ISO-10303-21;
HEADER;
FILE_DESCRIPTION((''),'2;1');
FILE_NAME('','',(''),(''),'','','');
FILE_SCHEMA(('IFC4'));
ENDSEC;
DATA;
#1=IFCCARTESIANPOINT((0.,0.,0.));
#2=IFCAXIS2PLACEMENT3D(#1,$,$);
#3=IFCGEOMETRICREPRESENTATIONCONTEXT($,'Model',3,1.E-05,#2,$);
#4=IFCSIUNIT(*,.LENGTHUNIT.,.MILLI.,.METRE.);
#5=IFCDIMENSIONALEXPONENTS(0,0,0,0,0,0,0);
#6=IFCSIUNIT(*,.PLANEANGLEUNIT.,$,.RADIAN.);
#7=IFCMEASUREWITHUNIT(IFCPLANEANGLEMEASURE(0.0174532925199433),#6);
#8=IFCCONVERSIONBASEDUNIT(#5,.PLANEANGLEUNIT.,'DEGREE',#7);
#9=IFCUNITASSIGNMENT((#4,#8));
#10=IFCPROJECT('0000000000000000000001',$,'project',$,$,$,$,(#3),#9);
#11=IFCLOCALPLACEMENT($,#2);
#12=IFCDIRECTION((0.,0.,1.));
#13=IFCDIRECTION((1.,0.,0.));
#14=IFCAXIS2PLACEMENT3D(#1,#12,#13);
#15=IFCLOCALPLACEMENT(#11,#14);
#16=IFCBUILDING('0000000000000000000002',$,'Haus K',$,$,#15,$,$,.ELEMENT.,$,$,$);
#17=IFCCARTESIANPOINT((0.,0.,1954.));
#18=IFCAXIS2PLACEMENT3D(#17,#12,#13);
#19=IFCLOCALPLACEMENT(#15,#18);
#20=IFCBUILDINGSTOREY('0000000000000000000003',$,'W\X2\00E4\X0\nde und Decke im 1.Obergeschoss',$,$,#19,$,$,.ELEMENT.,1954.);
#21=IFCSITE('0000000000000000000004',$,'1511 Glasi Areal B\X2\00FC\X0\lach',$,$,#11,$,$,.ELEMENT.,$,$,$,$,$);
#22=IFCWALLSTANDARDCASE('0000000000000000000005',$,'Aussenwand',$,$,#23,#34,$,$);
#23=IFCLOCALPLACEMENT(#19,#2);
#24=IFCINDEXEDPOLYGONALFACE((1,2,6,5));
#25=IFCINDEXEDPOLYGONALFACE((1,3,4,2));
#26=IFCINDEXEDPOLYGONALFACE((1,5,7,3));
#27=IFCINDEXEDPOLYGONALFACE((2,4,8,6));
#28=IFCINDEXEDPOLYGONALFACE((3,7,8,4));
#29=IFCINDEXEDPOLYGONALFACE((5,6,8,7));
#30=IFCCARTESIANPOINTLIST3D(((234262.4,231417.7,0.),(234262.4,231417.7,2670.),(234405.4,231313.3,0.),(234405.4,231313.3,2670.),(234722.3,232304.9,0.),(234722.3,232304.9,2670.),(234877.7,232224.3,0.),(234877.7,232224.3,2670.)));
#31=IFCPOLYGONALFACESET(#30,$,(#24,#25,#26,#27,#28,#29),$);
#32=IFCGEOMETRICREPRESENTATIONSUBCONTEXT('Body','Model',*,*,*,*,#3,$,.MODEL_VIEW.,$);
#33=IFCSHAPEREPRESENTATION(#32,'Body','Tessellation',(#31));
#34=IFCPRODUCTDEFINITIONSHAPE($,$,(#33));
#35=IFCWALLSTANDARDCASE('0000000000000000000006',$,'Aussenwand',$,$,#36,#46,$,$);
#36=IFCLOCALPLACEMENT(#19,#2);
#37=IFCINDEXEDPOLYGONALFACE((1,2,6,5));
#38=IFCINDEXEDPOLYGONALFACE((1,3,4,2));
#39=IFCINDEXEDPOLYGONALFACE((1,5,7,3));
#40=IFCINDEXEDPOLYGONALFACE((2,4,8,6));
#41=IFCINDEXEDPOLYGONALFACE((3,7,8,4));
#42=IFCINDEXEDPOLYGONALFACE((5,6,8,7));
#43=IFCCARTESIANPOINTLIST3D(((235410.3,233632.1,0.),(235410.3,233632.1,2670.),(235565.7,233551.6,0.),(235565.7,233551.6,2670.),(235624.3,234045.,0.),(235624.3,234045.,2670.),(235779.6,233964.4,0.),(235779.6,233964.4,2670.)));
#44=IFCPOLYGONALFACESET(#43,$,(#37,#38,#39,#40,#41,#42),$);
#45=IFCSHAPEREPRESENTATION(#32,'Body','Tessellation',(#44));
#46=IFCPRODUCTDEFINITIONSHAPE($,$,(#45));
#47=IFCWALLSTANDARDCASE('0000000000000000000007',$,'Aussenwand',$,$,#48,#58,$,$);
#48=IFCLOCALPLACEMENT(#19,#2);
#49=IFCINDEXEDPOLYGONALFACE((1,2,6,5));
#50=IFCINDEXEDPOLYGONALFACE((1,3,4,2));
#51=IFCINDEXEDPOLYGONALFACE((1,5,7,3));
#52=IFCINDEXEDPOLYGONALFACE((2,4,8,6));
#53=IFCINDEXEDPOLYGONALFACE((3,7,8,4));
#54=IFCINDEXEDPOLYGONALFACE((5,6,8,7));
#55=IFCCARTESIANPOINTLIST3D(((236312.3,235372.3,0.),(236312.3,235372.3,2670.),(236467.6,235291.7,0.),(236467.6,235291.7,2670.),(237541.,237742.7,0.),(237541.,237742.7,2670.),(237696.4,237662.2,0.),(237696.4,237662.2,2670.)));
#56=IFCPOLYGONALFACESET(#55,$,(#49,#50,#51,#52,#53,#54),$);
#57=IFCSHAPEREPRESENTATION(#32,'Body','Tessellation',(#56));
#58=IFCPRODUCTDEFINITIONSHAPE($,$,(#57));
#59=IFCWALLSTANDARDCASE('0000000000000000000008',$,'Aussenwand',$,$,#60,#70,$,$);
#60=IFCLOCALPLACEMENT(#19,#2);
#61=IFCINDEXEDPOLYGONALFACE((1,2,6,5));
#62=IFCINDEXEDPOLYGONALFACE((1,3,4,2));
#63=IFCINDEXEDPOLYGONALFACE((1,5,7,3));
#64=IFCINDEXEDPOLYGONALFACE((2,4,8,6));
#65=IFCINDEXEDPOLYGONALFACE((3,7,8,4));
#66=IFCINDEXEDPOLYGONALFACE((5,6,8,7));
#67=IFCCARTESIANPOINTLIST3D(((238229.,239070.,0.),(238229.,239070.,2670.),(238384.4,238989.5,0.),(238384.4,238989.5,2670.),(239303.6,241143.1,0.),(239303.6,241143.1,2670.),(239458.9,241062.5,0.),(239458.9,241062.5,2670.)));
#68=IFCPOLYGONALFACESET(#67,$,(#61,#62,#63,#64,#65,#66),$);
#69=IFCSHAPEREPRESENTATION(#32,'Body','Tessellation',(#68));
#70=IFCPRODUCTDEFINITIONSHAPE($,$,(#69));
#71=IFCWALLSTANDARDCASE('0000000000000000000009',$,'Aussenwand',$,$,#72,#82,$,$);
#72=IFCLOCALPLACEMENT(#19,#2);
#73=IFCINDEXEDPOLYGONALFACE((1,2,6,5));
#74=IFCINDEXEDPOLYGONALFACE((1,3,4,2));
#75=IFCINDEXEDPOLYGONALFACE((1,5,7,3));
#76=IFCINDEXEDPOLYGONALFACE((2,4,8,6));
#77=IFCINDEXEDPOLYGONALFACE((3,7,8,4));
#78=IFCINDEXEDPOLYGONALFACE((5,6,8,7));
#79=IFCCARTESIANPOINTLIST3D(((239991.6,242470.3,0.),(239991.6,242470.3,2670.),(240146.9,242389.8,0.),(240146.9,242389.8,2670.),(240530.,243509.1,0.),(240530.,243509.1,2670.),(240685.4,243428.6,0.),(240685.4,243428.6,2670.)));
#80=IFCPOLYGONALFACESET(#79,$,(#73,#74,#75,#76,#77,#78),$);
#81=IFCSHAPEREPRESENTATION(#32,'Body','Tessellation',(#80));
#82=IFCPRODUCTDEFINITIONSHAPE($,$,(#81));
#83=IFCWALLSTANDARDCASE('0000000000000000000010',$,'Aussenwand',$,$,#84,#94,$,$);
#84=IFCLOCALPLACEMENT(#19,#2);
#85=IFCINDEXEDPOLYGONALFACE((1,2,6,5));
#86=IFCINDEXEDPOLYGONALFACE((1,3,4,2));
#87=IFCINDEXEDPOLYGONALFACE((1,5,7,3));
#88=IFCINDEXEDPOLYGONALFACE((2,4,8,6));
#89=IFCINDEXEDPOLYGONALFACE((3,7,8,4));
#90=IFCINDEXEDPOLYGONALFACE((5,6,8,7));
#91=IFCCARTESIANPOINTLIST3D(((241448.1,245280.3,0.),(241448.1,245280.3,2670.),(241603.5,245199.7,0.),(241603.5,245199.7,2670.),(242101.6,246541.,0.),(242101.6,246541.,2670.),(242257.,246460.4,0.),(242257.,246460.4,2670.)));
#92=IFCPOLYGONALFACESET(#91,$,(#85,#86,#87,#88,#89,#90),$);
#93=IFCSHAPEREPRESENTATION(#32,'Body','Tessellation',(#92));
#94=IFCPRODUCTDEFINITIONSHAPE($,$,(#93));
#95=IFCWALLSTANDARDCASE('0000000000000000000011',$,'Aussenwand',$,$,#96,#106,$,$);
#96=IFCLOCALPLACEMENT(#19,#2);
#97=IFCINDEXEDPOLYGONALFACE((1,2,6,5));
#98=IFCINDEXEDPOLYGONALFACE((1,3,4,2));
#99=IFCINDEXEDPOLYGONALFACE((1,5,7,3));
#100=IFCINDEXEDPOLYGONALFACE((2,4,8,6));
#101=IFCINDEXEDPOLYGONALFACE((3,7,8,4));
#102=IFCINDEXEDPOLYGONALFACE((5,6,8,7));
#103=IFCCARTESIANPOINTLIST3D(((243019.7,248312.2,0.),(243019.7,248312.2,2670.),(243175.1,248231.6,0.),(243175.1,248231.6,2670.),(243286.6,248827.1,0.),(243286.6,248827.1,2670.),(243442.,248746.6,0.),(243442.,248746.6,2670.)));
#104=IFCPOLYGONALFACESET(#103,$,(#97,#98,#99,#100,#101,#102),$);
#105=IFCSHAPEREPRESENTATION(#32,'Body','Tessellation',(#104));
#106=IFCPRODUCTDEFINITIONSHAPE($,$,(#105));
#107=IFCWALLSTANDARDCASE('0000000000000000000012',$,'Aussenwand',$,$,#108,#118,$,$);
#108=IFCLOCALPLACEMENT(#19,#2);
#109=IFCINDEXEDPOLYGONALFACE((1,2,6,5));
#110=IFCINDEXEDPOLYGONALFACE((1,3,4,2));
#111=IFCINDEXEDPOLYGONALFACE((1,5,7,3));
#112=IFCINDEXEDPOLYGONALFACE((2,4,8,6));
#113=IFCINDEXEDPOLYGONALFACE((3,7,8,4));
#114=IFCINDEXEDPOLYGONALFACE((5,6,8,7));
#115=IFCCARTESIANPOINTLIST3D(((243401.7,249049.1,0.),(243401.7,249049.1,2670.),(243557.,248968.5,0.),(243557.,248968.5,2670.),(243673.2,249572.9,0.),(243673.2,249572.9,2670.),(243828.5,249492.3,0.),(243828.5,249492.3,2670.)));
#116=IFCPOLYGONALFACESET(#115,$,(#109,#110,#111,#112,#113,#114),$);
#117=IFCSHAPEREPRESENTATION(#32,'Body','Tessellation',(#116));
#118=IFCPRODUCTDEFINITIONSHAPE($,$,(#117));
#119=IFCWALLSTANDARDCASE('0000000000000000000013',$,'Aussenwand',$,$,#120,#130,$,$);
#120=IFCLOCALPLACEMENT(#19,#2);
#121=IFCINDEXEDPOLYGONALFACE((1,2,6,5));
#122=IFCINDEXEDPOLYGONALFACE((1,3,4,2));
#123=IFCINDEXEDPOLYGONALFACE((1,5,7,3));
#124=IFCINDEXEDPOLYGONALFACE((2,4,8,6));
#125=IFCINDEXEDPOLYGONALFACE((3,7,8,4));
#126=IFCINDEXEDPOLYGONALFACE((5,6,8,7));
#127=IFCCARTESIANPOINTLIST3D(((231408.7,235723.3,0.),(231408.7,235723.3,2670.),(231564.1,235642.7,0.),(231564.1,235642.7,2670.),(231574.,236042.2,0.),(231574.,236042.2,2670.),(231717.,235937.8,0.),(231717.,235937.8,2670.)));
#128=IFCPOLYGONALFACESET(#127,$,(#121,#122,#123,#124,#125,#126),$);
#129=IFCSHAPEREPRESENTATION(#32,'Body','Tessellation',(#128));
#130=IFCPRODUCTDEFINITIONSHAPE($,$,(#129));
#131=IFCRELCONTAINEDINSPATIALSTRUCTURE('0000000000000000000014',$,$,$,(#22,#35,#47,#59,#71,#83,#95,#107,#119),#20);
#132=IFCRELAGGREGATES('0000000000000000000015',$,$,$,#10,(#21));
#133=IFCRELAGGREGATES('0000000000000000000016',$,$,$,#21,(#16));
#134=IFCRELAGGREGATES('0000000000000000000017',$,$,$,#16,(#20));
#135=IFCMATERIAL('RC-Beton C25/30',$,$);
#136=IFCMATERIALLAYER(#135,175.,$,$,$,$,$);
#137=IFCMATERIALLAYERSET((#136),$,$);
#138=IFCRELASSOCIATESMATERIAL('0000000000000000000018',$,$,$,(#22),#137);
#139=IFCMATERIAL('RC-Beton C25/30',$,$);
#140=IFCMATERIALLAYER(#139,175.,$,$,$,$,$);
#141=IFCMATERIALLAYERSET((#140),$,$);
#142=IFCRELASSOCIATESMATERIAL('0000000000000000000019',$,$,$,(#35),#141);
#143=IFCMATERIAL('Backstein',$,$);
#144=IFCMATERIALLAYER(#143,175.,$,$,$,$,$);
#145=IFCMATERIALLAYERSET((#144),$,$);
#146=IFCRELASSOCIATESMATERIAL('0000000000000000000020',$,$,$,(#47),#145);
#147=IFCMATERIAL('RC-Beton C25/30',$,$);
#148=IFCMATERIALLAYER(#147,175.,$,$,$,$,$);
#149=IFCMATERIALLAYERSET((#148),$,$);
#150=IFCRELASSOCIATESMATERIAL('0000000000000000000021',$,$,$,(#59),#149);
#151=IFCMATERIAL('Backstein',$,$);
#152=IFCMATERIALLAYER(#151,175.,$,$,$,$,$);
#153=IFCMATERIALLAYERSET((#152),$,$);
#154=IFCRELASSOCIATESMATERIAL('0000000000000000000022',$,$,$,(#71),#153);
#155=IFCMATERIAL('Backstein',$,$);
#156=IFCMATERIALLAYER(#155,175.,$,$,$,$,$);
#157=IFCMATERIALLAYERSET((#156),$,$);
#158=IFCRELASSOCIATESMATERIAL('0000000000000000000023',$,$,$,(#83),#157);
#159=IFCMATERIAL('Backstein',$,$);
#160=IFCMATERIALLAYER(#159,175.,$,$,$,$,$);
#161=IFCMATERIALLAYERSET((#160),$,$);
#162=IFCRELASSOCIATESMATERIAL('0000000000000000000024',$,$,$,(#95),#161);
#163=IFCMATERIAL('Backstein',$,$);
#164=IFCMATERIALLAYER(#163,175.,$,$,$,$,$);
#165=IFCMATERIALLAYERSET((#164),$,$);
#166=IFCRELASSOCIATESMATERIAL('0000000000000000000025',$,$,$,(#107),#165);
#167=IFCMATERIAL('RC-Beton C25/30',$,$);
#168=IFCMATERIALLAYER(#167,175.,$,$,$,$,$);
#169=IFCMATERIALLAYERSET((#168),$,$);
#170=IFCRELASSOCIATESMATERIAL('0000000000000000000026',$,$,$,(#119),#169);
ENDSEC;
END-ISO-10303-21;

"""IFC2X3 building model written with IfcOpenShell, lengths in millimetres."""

from ifc_helpers import new_model, entity, si_unit, converted_unit, frame, frame_2d, origin, origin_with_axes, place, context, subcontext, project, spatial, polyline, rectangle, outline, extrude, material, layer, layer_set, layer_usage, element, save


model = new_model("IFC2X3")

# Units and contexts
model_context = context("Model", 3, precision=1e-05, world=origin())
body_context = subcontext(model_context, "Body", "Model", "MODEL_VIEW")
ifc_project = project(units=[si_unit("LENGTHUNIT", "METRE", prefix="MILLI"), converted_unit("PLANEANGLEUNIT", "DEGREE", entity("IfcPlaneAngleMeasure", 0.0174532925199433), si_unit("PLANEANGLEUNIT", "RADIAN"), dimensions=[0, 0, 0, 0, 0, 0, 0])], contexts=[model_context])

# Site, building, storey
site_placement = place(None, origin())
site = spatial("IfcSite", under=ifc_project, at=site_placement, Name="1511 Glasi Areal Bülach", CompositionType="ELEMENT")
building_placement = place(site_placement, origin_with_axes())
building = spatial("IfcBuilding", under=site, at=building_placement, Name="Haus K", CompositionType="ELEMENT")
storey_placement = place(building_placement, frame((0.0, 0.0, 1954.0), z_axis=(0.0, 0.0, 1.0), x_axis=(1.0, 0.0, 0.0)))
storey = spatial("IfcBuildingStorey", under=building, at=storey_placement, Name="Wände und Decke im 1.Obergeschoss", CompositionType="ELEMENT", Elevation=1954.0)

# Walls
ifc_material_1 = material(Name="RC-Beton C25/30")
ifc_layer_1 = layer(ifc_material_1, 175.0)
ifc_layer_set_1 = layer_set([ifc_layer_1])
ifc_layer_usage_1 = layer_usage(ifc_layer_set_1, "AXIS2", "POSITIVE", 0.0)
wall_1_placement = place(storey_placement, frame((234405.4, 231313.3, 0.0), z_axis=(0.0, 0.0, 1.0), x_axis=(0.4602, 0.887815, 0.0)))
element("IfcWallStandardCase", 1, at=wall_1_placement, inside=storey, material=ifc_layer_usage_1, Name="Aussenwand", context=body_context, shape_type="SweptSolid", body=[
    extrude(outline(polyline([(0.0, 0.0), (1026.2, 0.0), (1026.2, 175.0), (26.9, 175.0), (0.0, 0.0)])), origin_with_axes(), (0.0, 0.0, 1.0), 2670.0),
])
ifc_material_2 = material(Name="RC-Beton C25/30")
ifc_layer_2 = layer(ifc_material_2, 175.0)
ifc_layer_set_2 = layer_set([ifc_layer_2])
ifc_layer_usage_2 = layer_usage(ifc_layer_set_2, "AXIS2", "POSITIVE", 0.0)
wall_2_placement = place(storey_placement, frame((235565.7, 233551.6, 0.0), z_axis=(0.0, 0.0, 1.0), x_axis=(0.4602, 0.887815, 0.0)))
element("IfcWallStandardCase", 2, at=wall_2_placement, inside=storey, material=ifc_layer_usage_2, Name="Aussenwand", context=body_context, shape_type="SweptSolid", body=[
    extrude(rectangle(XDim=465.0, YDim=175.0, at=frame_2d((232.5, 87.5), x_axis=(1.0, 0.0))), origin_with_axes(), (0.0, 0.0, 1.0), 2670.0),
])
ifc_material_3 = material(Name="Backstein")
ifc_layer_3 = layer(ifc_material_3, 175.0)
ifc_layer_set_3 = layer_set([ifc_layer_3])
ifc_layer_usage_3 = layer_usage(ifc_layer_set_3, "AXIS2", "POSITIVE", 0.0)
wall_3_placement = place(storey_placement, frame((236467.6, 235291.7, 0.0), z_axis=(0.0, 0.0, 1.0), x_axis=(0.4602, 0.887815, 0.0)))
element("IfcWallStandardCase", 3, at=wall_3_placement, inside=storey, material=ifc_layer_usage_3, Name="Aussenwand", context=body_context, shape_type="SweptSolid", body=[
    extrude(rectangle(XDim=2670.0, YDim=175.0, at=frame_2d((1335.0, 87.5), x_axis=(1.0, 0.0))), origin_with_axes(), (0.0, 0.0, 1.0), 2670.0),
])
ifc_material_4 = material(Name="RC-Beton C25/30")
ifc_layer_4 = layer(ifc_material_4, 175.0)
ifc_layer_set_4 = layer_set([ifc_layer_4])
ifc_layer_usage_4 = layer_usage(ifc_layer_set_4, "AXIS2", "POSITIVE", 0.0)
wall_4_placement = place(storey_placement, frame((238384.4, 238989.5, 0.0), z_axis=(0.0, 0.0, 1.0), x_axis=(0.4602, 0.887815, 0.0)))
element("IfcWallStandardCase", 4, at=wall_4_placement, inside=storey, material=ifc_layer_usage_4, Name="Aussenwand", context=body_context, shape_type="SweptSolid", body=[
    extrude(rectangle(XDim=2335.0, YDim=175.0, at=frame_2d((1167.5, 87.5), x_axis=(1.0, 0.0))), origin_with_axes(), (0.0, 0.0, 1.0), 2670.0),
])
ifc_material_5 = material(Name="Backstein")
ifc_layer_5 = layer(ifc_material_5, 175.0)
ifc_layer_set_5 = layer_set([ifc_layer_5])
ifc_layer_usage_5 = layer_usage(ifc_layer_set_5, "AXIS2", "POSITIVE", 0.0)
wall_5_placement = place(storey_placement, frame((240146.9, 242389.8, 0.0), z_axis=(0.0, 0.0, 1.0), x_axis=(0.4602, 0.887815, 0.0)))
element("IfcWallStandardCase", 5, at=wall_5_placement, inside=storey, material=ifc_layer_usage_5, Name="Aussenwand", context=body_context, shape_type="SweptSolid", body=[
    extrude(rectangle(XDim=1170.0, YDim=175.0, at=frame_2d((585.0, 87.5), x_axis=(1.0, 0.0))), origin_with_axes(), (0.0, 0.0, 1.0), 2670.0),
])
ifc_material_6 = material(Name="Backstein")
ifc_layer_6 = layer(ifc_material_6, 175.0)
ifc_layer_set_6 = layer_set([ifc_layer_6])
ifc_layer_usage_6 = layer_usage(ifc_layer_set_6, "AXIS2", "POSITIVE", 0.0)
wall_6_placement = place(storey_placement, frame((241603.5, 245199.7, 0.0), z_axis=(0.0, 0.0, 1.0), x_axis=(0.4602, 0.887815, 0.0)))
element("IfcWallStandardCase", 6, at=wall_6_placement, inside=storey, material=ifc_layer_usage_6, Name="Aussenwand", context=body_context, shape_type="SweptSolid", body=[
    extrude(rectangle(XDim=1420.0, YDim=175.0, at=frame_2d((710.0, 87.5), x_axis=(1.0, 0.0))), origin_with_axes(), (0.0, 0.0, 1.0), 2670.0),
])
ifc_material_7 = material(Name="Backstein")
ifc_layer_7 = layer(ifc_material_7, 175.0)
ifc_layer_set_7 = layer_set([ifc_layer_7])
ifc_layer_usage_7 = layer_usage(ifc_layer_set_7, "AXIS2", "POSITIVE", 0.0)
wall_7_placement = place(storey_placement, frame((243175.1, 248231.6, 0.0), z_axis=(0.0, 0.0, 1.0), x_axis=(0.4602, 0.887815, 0.0)))
element("IfcWallStandardCase", 7, at=wall_7_placement, inside=storey, material=ifc_layer_usage_7, Name="Aussenwand", context=body_context, shape_type="SweptSolid", body=[
    extrude(rectangle(XDim=580.0, YDim=175.0, at=frame_2d((290.0, 87.5), x_axis=(1.0, 0.0))), origin_with_axes(), (0.0, 0.0, 1.0), 2670.0),
])
ifc_material_8 = material(Name="Backstein")
ifc_layer_8 = layer(ifc_material_8, 175.0)
ifc_layer_set_8 = layer_set([ifc_layer_8])
ifc_layer_usage_8 = layer_usage(ifc_layer_set_8, "AXIS2", "POSITIVE", 0.0)
wall_8_placement = place(storey_placement, frame((243557.0, 248968.5, 0.0), z_axis=(0.0, 0.0, 1.0), x_axis=(0.4602, 0.887815, 0.0)))
element("IfcWallStandardCase", 8, at=wall_8_placement, inside=storey, material=ifc_layer_usage_8, Name="Aussenwand", context=body_context, shape_type="SweptSolid", body=[
    extrude(rectangle(XDim=590.0, YDim=175.0, at=frame_2d((295.0, 87.5), x_axis=(1.0, 0.0))), origin_with_axes(), (0.0, 0.0, 1.0), 2670.0),
])
ifc_material_9 = material(Name="RC-Beton C25/30")
ifc_layer_9 = layer(ifc_material_9, 175.0)
ifc_layer_set_9 = layer_set([ifc_layer_9])
ifc_layer_usage_9 = layer_usage(ifc_layer_set_9, "AXIS2", "POSITIVE", 0.0)
wall_9_placement = place(storey_placement, frame((231574.0, 236042.2, 0.0), z_axis=(0.0, 0.0, 1.0), x_axis=(-0.4602, -0.887815, 0.0)))
element("IfcWallStandardCase", 9, at=wall_9_placement, inside=storey, material=ifc_layer_usage_9, Name="Aussenwand", context=body_context, shape_type="SweptSolid", body=[
    extrude(outline(polyline([(0.0, 0.0), (359.2, 0.0), (359.2, 175.0), (26.9, 175.0), (0.0, 0.0)])), origin_with_axes(), (0.0, 0.0, 1.0), 2670.0),
])

save(model, "model.ifc")
